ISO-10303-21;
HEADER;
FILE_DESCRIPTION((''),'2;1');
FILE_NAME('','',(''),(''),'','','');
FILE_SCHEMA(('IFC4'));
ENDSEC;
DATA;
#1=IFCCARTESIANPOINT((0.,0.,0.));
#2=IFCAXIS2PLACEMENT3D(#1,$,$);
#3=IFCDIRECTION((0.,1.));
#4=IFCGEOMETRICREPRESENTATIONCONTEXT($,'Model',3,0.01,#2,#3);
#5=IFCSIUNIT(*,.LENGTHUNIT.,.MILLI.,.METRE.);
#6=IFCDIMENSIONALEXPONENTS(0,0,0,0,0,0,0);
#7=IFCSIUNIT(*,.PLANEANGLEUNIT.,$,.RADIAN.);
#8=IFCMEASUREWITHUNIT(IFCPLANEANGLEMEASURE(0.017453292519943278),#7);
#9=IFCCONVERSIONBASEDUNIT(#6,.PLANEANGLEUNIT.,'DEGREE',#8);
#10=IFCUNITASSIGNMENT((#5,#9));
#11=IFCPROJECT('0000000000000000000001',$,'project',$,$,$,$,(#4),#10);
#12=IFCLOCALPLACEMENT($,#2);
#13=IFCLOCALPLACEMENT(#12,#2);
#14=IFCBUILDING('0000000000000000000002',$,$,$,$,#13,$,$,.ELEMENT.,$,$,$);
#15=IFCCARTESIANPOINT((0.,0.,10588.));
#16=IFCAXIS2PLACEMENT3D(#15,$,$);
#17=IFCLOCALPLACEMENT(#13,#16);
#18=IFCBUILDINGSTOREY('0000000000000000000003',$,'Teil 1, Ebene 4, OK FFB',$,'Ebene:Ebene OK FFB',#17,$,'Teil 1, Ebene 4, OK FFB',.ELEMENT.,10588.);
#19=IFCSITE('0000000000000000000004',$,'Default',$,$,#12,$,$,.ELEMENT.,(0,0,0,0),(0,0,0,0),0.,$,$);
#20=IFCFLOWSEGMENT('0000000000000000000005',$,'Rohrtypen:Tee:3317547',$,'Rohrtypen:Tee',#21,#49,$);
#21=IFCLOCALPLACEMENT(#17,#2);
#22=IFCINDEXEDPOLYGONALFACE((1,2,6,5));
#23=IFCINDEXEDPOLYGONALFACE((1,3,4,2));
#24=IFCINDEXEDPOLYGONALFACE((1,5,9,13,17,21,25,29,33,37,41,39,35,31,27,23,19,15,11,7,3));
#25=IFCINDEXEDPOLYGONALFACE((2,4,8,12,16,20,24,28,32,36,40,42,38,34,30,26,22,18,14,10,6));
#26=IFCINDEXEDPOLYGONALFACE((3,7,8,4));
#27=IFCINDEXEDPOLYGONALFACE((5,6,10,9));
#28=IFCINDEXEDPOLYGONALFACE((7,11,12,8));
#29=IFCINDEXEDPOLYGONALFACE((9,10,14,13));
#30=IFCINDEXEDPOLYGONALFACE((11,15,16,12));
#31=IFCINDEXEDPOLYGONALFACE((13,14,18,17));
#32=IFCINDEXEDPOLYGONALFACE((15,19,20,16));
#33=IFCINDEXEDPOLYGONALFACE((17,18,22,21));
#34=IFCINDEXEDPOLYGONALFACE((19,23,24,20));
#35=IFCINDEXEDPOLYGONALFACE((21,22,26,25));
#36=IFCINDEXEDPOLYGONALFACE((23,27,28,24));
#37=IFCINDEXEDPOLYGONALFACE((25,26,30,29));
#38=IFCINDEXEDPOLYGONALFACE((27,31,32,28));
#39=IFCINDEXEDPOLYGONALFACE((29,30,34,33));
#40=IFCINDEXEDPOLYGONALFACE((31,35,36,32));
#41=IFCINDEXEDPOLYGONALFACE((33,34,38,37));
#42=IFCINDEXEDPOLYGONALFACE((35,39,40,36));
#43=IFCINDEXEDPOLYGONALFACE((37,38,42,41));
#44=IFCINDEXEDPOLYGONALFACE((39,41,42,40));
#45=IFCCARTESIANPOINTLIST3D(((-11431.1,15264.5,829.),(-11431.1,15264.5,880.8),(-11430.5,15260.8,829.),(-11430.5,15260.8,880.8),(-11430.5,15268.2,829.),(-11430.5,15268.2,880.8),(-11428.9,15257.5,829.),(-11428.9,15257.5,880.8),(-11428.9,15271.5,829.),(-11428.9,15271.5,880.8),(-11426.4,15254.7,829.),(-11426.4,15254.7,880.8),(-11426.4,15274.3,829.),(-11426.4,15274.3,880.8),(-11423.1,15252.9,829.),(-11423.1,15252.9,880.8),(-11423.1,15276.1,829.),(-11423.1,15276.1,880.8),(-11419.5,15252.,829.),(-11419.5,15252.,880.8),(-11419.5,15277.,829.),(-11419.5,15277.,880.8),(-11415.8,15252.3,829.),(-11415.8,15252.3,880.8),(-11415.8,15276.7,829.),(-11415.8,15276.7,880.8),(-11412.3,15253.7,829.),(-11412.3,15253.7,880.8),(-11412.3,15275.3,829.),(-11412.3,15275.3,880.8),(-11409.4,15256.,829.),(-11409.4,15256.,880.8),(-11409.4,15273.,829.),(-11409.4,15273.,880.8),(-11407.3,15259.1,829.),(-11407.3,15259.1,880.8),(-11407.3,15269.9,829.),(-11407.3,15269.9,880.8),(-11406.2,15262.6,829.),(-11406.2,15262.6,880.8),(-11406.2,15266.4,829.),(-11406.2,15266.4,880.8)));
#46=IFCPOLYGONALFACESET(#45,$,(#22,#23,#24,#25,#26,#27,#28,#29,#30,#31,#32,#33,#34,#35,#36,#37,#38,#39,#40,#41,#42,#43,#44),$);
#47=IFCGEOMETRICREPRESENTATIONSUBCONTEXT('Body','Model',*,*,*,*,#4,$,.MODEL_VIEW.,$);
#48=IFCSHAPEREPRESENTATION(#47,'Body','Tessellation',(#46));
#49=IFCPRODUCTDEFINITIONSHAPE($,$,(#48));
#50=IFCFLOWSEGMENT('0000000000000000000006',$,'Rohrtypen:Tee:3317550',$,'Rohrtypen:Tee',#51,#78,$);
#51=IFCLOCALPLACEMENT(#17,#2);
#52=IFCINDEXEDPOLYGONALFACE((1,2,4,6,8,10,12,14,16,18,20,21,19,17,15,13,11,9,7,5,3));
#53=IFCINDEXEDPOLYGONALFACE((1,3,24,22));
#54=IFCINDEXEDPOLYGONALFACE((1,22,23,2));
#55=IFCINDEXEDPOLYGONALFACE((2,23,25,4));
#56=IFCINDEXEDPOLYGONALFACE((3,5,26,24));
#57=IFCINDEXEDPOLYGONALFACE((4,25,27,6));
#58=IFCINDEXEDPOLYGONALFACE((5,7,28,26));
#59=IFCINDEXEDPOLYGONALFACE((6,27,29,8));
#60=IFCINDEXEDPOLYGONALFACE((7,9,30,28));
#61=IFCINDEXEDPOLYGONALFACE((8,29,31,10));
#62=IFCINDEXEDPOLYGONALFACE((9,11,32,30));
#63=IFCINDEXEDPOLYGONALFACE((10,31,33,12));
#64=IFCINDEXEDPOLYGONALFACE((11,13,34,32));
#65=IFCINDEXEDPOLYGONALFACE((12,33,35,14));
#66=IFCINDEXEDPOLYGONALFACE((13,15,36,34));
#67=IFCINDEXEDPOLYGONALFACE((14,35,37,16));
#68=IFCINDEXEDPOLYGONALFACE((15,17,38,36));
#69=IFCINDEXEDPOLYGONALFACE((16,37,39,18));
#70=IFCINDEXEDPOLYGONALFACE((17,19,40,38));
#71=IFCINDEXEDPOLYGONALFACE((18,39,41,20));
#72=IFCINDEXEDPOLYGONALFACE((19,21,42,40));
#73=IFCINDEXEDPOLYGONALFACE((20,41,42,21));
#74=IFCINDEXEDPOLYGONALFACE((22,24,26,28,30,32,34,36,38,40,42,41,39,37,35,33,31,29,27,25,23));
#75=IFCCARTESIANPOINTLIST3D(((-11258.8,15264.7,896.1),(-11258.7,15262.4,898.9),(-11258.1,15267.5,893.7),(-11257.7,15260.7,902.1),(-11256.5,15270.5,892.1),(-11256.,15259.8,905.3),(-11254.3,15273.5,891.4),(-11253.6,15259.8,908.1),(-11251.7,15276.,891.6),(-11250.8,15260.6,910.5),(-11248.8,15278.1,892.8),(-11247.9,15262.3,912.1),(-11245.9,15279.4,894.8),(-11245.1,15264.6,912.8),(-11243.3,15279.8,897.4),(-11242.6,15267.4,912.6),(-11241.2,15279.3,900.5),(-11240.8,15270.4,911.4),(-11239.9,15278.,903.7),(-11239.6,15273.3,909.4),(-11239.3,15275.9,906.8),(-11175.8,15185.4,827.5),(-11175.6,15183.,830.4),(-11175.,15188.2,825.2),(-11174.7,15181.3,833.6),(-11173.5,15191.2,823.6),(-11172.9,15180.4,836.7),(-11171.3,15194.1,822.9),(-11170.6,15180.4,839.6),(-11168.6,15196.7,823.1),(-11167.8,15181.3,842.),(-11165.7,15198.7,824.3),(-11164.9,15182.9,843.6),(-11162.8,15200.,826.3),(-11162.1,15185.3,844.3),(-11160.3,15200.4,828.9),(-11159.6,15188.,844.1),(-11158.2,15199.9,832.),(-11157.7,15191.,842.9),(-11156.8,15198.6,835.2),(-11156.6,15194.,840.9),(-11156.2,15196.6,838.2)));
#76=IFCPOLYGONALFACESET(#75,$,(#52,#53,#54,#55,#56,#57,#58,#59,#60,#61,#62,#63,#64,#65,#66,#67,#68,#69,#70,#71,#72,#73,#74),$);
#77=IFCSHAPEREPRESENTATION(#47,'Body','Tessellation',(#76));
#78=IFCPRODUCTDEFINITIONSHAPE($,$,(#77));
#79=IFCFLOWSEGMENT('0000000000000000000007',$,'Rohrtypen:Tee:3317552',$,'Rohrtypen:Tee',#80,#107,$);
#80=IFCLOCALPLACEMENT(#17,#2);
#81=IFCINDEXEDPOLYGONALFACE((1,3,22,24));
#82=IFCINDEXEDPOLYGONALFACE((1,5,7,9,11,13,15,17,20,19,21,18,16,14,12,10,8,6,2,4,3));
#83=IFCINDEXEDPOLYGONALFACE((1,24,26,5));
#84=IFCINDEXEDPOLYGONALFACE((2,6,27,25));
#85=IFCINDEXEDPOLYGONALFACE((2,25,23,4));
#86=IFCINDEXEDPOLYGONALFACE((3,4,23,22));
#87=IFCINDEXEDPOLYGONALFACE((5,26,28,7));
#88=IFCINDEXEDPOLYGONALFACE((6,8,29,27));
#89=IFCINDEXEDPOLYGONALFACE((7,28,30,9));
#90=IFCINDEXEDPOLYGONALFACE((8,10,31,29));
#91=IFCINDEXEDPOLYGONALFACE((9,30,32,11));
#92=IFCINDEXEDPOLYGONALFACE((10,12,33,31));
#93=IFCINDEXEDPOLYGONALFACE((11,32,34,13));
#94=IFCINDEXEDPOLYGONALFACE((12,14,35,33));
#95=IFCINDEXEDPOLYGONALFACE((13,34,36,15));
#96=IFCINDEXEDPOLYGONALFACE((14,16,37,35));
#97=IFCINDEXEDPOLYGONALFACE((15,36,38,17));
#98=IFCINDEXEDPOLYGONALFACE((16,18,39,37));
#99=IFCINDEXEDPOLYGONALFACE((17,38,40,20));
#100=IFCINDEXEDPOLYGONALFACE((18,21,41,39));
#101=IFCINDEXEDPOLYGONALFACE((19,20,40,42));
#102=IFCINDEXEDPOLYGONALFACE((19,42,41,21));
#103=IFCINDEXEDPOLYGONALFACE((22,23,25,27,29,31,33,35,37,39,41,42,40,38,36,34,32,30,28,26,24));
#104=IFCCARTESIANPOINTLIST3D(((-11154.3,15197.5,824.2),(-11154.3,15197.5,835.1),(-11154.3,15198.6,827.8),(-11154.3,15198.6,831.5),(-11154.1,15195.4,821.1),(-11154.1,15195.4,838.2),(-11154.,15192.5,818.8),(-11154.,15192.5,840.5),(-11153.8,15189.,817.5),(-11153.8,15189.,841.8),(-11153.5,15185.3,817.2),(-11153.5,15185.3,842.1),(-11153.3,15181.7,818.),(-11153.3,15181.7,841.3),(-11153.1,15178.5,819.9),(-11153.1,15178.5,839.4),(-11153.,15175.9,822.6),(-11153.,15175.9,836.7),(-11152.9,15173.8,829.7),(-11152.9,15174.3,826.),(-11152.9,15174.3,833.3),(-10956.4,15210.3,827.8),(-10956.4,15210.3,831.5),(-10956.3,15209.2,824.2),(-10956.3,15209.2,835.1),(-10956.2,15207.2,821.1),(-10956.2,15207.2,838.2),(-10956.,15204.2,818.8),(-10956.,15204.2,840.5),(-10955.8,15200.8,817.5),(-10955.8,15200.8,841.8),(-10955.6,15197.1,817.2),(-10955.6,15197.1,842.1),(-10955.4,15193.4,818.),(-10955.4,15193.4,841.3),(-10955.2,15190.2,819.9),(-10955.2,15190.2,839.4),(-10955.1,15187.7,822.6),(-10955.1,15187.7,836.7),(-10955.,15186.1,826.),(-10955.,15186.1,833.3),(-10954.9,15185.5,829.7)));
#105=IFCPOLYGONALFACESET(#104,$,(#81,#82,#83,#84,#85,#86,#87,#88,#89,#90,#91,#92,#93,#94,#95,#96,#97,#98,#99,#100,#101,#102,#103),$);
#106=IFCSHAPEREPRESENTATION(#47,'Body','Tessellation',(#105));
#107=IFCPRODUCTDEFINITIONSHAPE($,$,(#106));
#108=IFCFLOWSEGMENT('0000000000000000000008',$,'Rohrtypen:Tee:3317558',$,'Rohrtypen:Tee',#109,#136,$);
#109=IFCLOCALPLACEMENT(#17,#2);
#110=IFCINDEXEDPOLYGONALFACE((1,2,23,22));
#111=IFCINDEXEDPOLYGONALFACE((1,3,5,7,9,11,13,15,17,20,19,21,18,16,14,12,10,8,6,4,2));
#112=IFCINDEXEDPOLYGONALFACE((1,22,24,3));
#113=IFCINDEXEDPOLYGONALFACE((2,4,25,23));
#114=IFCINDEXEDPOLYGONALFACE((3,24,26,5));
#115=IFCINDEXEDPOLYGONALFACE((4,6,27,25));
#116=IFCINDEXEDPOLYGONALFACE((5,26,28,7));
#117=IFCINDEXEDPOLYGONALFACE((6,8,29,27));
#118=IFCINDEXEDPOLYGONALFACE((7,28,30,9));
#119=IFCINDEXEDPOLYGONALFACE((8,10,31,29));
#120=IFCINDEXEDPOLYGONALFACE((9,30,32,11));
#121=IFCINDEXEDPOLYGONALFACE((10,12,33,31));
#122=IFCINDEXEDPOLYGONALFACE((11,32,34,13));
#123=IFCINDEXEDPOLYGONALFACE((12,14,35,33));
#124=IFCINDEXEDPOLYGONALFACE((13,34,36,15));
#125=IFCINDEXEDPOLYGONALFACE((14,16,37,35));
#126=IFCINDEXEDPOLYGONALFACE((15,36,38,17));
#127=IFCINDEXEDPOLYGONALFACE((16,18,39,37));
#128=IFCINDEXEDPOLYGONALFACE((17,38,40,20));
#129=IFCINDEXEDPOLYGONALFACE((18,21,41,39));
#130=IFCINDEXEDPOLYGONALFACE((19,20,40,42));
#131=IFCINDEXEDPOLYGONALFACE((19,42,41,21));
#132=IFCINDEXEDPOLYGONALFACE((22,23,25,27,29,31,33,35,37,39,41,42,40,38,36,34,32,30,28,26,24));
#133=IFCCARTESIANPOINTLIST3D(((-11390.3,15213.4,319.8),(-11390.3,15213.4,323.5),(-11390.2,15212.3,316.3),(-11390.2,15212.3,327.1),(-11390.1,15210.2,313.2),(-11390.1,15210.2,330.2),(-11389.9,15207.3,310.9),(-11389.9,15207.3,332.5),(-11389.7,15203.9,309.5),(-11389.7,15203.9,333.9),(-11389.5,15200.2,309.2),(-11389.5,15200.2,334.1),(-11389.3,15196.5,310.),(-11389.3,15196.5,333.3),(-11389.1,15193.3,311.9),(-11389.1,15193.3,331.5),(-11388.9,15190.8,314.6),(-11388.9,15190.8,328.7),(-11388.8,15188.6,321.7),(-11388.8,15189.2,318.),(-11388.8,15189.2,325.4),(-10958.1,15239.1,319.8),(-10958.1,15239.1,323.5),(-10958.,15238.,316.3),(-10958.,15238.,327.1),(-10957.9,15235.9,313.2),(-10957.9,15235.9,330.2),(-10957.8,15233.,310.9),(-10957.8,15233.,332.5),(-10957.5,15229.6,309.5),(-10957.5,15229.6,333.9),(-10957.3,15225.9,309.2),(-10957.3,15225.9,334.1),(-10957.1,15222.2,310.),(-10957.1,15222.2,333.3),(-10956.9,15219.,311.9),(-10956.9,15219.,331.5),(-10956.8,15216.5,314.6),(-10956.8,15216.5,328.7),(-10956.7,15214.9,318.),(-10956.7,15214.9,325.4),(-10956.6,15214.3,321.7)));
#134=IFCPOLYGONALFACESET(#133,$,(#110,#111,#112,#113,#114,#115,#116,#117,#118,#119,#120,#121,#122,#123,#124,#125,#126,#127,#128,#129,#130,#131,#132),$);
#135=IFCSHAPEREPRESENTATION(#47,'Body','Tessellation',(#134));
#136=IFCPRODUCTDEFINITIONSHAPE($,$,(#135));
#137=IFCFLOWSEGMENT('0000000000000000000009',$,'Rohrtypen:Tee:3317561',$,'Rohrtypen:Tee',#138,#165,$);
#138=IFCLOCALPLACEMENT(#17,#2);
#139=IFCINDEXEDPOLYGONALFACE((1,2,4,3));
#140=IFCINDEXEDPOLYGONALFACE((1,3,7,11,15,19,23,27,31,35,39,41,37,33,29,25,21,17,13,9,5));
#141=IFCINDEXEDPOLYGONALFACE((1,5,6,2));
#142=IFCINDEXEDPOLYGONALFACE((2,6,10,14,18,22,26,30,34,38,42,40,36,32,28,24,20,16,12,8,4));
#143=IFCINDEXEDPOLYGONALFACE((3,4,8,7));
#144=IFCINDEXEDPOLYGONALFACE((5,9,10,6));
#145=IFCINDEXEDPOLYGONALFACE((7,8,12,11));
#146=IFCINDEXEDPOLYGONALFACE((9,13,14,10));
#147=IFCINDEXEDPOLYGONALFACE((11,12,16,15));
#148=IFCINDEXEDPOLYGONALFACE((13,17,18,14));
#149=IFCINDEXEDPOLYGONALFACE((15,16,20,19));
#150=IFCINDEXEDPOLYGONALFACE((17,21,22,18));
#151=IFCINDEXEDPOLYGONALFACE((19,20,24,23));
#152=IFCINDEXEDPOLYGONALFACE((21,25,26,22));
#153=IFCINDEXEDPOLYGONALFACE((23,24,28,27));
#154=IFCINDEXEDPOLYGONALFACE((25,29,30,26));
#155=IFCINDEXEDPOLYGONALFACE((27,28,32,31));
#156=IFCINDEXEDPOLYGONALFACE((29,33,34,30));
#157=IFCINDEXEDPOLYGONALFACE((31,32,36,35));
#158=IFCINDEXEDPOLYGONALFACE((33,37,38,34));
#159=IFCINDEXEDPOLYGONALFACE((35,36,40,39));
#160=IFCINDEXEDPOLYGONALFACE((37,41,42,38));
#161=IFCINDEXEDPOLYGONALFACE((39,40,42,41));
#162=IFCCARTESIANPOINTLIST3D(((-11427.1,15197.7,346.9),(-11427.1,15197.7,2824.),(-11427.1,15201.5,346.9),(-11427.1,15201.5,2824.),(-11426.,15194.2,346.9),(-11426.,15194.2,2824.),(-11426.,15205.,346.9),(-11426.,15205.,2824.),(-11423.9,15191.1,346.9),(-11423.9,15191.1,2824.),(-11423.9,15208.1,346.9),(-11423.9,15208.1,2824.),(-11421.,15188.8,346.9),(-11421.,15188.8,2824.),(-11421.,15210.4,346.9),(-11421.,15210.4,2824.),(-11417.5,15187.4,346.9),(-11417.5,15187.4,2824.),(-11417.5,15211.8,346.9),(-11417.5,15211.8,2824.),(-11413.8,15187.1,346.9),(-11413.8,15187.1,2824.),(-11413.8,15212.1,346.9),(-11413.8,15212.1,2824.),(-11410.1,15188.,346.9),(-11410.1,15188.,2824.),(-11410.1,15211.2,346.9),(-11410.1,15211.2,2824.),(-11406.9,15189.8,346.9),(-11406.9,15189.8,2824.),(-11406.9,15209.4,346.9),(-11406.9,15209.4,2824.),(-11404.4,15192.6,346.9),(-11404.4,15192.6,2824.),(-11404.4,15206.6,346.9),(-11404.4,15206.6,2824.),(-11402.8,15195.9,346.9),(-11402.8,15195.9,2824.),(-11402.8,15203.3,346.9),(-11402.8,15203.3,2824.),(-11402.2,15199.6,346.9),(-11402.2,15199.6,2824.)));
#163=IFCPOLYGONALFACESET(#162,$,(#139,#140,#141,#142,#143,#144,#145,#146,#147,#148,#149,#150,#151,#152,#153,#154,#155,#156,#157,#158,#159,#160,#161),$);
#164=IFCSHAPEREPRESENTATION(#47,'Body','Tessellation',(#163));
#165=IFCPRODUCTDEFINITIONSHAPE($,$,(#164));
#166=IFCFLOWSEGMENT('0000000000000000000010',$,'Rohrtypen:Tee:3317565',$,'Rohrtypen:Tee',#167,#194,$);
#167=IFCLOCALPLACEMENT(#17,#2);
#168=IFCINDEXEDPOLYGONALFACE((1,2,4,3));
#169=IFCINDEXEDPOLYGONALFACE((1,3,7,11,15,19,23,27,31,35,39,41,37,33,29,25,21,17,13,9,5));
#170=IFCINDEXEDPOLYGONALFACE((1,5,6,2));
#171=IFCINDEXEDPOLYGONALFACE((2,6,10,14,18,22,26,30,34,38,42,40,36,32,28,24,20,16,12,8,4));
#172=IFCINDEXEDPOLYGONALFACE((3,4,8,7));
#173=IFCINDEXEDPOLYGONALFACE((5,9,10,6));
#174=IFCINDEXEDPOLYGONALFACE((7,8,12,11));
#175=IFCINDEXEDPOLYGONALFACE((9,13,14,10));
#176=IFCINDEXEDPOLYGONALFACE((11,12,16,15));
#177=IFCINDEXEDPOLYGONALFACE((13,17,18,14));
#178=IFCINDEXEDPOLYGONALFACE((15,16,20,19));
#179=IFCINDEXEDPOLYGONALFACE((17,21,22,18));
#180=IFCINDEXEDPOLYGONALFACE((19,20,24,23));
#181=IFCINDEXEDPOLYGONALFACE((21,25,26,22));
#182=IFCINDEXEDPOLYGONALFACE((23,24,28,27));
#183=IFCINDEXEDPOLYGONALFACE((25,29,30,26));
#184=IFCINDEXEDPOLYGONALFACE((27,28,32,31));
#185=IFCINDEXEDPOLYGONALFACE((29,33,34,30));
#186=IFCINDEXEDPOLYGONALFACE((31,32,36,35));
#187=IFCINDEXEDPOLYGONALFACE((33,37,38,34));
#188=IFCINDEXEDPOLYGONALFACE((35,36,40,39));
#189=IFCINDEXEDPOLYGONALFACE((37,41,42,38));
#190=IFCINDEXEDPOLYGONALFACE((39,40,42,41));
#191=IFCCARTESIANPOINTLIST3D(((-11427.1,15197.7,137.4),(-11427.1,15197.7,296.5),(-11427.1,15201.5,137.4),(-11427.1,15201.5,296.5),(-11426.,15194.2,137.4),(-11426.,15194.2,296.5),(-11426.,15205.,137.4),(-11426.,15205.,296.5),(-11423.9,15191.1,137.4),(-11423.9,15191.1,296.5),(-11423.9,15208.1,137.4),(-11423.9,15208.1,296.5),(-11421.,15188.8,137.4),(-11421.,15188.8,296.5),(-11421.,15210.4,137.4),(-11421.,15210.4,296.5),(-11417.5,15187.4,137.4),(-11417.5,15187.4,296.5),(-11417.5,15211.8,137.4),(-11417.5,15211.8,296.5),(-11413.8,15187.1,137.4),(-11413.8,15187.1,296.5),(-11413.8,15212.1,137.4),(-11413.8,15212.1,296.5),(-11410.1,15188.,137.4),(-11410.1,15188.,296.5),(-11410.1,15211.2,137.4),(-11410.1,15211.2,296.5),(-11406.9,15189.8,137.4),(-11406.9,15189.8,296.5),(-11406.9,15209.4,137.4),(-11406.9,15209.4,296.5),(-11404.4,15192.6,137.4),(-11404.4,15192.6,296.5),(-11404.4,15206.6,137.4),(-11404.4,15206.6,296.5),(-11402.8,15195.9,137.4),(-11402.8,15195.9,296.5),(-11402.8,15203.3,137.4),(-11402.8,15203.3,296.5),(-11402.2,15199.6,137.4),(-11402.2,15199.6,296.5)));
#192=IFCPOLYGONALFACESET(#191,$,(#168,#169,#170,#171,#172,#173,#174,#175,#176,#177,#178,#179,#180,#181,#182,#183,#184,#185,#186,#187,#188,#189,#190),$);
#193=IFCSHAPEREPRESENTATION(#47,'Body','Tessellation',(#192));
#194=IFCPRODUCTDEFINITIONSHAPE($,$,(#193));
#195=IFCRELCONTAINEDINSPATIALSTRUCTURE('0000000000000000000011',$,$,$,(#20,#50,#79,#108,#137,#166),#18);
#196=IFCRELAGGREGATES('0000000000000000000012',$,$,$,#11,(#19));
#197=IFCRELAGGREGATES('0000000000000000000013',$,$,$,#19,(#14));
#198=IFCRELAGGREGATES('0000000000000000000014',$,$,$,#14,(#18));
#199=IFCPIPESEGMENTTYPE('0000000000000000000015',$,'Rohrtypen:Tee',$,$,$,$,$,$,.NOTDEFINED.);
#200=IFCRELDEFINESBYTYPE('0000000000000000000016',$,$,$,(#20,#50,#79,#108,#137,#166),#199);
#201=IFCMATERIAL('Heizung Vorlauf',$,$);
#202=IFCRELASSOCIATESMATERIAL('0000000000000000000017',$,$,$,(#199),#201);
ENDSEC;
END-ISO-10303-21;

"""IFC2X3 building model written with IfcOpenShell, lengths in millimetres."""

from ifc_helpers import new_model, entity, si_unit, converted_unit, direction, frame, frame_2d, origin, origin_2d_with_axis, place, context, subcontext, project, spatial, circle, extrude, material, type_object, element, save


model = new_model("IFC2X3")

# Units and contexts
model_context = context("Model", 3, precision=0.01, world=origin(), true_north=direction((0.0, 1.0)))
body_context = subcontext(model_context, "Body", "Model", "MODEL_VIEW")
ifc_project = project(units=[si_unit("LENGTHUNIT", "METRE", prefix="MILLI"), converted_unit("PLANEANGLEUNIT", "DEGREE", entity("IfcPlaneAngleMeasure", 0.017453292519943278), si_unit("PLANEANGLEUNIT", "RADIAN"), dimensions=[0, 0, 0, 0, 0, 0, 0])], contexts=[model_context])

# Site, building, storey
site_placement = place(None, origin())
site = spatial("IfcSite", under=ifc_project, at=site_placement, Name="Default", CompositionType="ELEMENT", RefLatitude=(0, 0, 0, 0), RefLongitude=(0, 0, 0, 0), RefElevation=0.0)
building_placement = place(site_placement, origin())
building = spatial("IfcBuilding", under=site, at=building_placement, CompositionType="ELEMENT")
storey_placement = place(building_placement, frame((0.0, 0.0, 10588.0)))
storey = spatial("IfcBuildingStorey", under=building, at=storey_placement, Name="Teil 1, Ebene 4, OK FFB", ObjectType="Ebene:Ebene OK FFB", LongName="Teil 1, Ebene 4, OK FFB", CompositionType="ELEMENT", Elevation=10588.0)

# Flow segments
ifc_material = material(Name="Heizung Vorlauf")
pipe_segment_type = type_object("IfcPipeSegmentType", Name="Rohrtypen:Tee", PredefinedType="NOTDEFINED", material=ifc_material)
flow_segment_1_placement = place(storey_placement, origin())
element("IfcFlowSegment", 1, at=flow_segment_1_placement, inside=storey, type_object=pipe_segment_type, Name="Rohrtypen:Tee:3317547", ObjectType="Rohrtypen:Tee", context=body_context, shape_type="SweptSolid", body=[
    extrude(circle(Radius=12.5, at=origin_2d_with_axis()), frame((-11418.6, 15264.5, 829.0), z_axis=(0.0, 0.0, 1.0), x_axis=(-1.0, 0.0, 0.0)), (0.0, 0.0, 1.0), 51.8),
])
flow_segment_2_placement = place(storey_placement, origin())
element("IfcFlowSegment", 2, at=flow_segment_2_placement, inside=storey, type_object=pipe_segment_type, Name="Rohrtypen:Tee:3317550", ObjectType="Rohrtypen:Tee", context=body_context, shape_type="SweptSolid", body=[
    extrude(circle(Radius=12.5, at=origin_2d_with_axis()), frame((-11166.0, 15190.3, 833.6), z_axis=(-0.620889, 0.593418, 0.512203), x_axis=(-0.690933, -0.722919, 0.0)), (0.0, 0.0, 1.0), 133.8),
])
flow_segment_3_placement = place(storey_placement, origin())
element("IfcFlowSegment", 3, at=flow_segment_3_placement, inside=storey, type_object=pipe_segment_type, Name="Rohrtypen:Tee:3317552", ObjectType="Rohrtypen:Tee", context=body_context, shape_type="SweptSolid", body=[
    extrude(circle(Radius=12.5, at=frame_2d((0.0, 0.0), x_axis=(1.0, 0.0))), frame((-11153.6, 15186.2, 829.7), z_axis=(0.998239, 0.059319, 0.0), x_axis=(0.059319, -0.998239, 0.0)), (0.0, 0.0, 1.0), 198.3),
])
flow_segment_4_placement = place(storey_placement, origin())
element("IfcFlowSegment", 4, at=flow_segment_4_placement, inside=storey, type_object=pipe_segment_type, Name="Rohrtypen:Tee:3317558", ObjectType="Rohrtypen:Tee", context=body_context, shape_type="SweptSolid", body=[
    extrude(circle(Radius=12.5, at=frame_2d((0.0, 0.0), x_axis=(1.0, 0.0))), frame((-11389.6, 15201.1, 321.7), z_axis=(0.998239, 0.059319, 0.0), x_axis=(0.059319, -0.998239, 0.0)), (0.0, 0.0, 1.0), 432.9),
])
flow_segment_5_placement = place(storey_placement, origin())
element("IfcFlowSegment", 5, at=flow_segment_5_placement, inside=storey, type_object=pipe_segment_type, Name="Rohrtypen:Tee:3317561", ObjectType="Rohrtypen:Tee", context=body_context, shape_type="SweptSolid", body=[
    extrude(circle(Radius=12.5, at=origin_2d_with_axis()), frame((-11414.7, 15199.6, 346.9)), (0.0, 0.0, 1.0), 2477.1),
])
flow_segment_6_placement = place(storey_placement, origin())
element("IfcFlowSegment", 6, at=flow_segment_6_placement, inside=storey, type_object=pipe_segment_type, Name="Rohrtypen:Tee:3317565", ObjectType="Rohrtypen:Tee", context=body_context, shape_type="SweptSolid", body=[
    extrude(circle(Radius=12.5, at=origin_2d_with_axis()), frame((-11414.7, 15199.6, 137.4)), (0.0, 0.0, 1.0), 159.0),
])

save(model, "model.ifc")
